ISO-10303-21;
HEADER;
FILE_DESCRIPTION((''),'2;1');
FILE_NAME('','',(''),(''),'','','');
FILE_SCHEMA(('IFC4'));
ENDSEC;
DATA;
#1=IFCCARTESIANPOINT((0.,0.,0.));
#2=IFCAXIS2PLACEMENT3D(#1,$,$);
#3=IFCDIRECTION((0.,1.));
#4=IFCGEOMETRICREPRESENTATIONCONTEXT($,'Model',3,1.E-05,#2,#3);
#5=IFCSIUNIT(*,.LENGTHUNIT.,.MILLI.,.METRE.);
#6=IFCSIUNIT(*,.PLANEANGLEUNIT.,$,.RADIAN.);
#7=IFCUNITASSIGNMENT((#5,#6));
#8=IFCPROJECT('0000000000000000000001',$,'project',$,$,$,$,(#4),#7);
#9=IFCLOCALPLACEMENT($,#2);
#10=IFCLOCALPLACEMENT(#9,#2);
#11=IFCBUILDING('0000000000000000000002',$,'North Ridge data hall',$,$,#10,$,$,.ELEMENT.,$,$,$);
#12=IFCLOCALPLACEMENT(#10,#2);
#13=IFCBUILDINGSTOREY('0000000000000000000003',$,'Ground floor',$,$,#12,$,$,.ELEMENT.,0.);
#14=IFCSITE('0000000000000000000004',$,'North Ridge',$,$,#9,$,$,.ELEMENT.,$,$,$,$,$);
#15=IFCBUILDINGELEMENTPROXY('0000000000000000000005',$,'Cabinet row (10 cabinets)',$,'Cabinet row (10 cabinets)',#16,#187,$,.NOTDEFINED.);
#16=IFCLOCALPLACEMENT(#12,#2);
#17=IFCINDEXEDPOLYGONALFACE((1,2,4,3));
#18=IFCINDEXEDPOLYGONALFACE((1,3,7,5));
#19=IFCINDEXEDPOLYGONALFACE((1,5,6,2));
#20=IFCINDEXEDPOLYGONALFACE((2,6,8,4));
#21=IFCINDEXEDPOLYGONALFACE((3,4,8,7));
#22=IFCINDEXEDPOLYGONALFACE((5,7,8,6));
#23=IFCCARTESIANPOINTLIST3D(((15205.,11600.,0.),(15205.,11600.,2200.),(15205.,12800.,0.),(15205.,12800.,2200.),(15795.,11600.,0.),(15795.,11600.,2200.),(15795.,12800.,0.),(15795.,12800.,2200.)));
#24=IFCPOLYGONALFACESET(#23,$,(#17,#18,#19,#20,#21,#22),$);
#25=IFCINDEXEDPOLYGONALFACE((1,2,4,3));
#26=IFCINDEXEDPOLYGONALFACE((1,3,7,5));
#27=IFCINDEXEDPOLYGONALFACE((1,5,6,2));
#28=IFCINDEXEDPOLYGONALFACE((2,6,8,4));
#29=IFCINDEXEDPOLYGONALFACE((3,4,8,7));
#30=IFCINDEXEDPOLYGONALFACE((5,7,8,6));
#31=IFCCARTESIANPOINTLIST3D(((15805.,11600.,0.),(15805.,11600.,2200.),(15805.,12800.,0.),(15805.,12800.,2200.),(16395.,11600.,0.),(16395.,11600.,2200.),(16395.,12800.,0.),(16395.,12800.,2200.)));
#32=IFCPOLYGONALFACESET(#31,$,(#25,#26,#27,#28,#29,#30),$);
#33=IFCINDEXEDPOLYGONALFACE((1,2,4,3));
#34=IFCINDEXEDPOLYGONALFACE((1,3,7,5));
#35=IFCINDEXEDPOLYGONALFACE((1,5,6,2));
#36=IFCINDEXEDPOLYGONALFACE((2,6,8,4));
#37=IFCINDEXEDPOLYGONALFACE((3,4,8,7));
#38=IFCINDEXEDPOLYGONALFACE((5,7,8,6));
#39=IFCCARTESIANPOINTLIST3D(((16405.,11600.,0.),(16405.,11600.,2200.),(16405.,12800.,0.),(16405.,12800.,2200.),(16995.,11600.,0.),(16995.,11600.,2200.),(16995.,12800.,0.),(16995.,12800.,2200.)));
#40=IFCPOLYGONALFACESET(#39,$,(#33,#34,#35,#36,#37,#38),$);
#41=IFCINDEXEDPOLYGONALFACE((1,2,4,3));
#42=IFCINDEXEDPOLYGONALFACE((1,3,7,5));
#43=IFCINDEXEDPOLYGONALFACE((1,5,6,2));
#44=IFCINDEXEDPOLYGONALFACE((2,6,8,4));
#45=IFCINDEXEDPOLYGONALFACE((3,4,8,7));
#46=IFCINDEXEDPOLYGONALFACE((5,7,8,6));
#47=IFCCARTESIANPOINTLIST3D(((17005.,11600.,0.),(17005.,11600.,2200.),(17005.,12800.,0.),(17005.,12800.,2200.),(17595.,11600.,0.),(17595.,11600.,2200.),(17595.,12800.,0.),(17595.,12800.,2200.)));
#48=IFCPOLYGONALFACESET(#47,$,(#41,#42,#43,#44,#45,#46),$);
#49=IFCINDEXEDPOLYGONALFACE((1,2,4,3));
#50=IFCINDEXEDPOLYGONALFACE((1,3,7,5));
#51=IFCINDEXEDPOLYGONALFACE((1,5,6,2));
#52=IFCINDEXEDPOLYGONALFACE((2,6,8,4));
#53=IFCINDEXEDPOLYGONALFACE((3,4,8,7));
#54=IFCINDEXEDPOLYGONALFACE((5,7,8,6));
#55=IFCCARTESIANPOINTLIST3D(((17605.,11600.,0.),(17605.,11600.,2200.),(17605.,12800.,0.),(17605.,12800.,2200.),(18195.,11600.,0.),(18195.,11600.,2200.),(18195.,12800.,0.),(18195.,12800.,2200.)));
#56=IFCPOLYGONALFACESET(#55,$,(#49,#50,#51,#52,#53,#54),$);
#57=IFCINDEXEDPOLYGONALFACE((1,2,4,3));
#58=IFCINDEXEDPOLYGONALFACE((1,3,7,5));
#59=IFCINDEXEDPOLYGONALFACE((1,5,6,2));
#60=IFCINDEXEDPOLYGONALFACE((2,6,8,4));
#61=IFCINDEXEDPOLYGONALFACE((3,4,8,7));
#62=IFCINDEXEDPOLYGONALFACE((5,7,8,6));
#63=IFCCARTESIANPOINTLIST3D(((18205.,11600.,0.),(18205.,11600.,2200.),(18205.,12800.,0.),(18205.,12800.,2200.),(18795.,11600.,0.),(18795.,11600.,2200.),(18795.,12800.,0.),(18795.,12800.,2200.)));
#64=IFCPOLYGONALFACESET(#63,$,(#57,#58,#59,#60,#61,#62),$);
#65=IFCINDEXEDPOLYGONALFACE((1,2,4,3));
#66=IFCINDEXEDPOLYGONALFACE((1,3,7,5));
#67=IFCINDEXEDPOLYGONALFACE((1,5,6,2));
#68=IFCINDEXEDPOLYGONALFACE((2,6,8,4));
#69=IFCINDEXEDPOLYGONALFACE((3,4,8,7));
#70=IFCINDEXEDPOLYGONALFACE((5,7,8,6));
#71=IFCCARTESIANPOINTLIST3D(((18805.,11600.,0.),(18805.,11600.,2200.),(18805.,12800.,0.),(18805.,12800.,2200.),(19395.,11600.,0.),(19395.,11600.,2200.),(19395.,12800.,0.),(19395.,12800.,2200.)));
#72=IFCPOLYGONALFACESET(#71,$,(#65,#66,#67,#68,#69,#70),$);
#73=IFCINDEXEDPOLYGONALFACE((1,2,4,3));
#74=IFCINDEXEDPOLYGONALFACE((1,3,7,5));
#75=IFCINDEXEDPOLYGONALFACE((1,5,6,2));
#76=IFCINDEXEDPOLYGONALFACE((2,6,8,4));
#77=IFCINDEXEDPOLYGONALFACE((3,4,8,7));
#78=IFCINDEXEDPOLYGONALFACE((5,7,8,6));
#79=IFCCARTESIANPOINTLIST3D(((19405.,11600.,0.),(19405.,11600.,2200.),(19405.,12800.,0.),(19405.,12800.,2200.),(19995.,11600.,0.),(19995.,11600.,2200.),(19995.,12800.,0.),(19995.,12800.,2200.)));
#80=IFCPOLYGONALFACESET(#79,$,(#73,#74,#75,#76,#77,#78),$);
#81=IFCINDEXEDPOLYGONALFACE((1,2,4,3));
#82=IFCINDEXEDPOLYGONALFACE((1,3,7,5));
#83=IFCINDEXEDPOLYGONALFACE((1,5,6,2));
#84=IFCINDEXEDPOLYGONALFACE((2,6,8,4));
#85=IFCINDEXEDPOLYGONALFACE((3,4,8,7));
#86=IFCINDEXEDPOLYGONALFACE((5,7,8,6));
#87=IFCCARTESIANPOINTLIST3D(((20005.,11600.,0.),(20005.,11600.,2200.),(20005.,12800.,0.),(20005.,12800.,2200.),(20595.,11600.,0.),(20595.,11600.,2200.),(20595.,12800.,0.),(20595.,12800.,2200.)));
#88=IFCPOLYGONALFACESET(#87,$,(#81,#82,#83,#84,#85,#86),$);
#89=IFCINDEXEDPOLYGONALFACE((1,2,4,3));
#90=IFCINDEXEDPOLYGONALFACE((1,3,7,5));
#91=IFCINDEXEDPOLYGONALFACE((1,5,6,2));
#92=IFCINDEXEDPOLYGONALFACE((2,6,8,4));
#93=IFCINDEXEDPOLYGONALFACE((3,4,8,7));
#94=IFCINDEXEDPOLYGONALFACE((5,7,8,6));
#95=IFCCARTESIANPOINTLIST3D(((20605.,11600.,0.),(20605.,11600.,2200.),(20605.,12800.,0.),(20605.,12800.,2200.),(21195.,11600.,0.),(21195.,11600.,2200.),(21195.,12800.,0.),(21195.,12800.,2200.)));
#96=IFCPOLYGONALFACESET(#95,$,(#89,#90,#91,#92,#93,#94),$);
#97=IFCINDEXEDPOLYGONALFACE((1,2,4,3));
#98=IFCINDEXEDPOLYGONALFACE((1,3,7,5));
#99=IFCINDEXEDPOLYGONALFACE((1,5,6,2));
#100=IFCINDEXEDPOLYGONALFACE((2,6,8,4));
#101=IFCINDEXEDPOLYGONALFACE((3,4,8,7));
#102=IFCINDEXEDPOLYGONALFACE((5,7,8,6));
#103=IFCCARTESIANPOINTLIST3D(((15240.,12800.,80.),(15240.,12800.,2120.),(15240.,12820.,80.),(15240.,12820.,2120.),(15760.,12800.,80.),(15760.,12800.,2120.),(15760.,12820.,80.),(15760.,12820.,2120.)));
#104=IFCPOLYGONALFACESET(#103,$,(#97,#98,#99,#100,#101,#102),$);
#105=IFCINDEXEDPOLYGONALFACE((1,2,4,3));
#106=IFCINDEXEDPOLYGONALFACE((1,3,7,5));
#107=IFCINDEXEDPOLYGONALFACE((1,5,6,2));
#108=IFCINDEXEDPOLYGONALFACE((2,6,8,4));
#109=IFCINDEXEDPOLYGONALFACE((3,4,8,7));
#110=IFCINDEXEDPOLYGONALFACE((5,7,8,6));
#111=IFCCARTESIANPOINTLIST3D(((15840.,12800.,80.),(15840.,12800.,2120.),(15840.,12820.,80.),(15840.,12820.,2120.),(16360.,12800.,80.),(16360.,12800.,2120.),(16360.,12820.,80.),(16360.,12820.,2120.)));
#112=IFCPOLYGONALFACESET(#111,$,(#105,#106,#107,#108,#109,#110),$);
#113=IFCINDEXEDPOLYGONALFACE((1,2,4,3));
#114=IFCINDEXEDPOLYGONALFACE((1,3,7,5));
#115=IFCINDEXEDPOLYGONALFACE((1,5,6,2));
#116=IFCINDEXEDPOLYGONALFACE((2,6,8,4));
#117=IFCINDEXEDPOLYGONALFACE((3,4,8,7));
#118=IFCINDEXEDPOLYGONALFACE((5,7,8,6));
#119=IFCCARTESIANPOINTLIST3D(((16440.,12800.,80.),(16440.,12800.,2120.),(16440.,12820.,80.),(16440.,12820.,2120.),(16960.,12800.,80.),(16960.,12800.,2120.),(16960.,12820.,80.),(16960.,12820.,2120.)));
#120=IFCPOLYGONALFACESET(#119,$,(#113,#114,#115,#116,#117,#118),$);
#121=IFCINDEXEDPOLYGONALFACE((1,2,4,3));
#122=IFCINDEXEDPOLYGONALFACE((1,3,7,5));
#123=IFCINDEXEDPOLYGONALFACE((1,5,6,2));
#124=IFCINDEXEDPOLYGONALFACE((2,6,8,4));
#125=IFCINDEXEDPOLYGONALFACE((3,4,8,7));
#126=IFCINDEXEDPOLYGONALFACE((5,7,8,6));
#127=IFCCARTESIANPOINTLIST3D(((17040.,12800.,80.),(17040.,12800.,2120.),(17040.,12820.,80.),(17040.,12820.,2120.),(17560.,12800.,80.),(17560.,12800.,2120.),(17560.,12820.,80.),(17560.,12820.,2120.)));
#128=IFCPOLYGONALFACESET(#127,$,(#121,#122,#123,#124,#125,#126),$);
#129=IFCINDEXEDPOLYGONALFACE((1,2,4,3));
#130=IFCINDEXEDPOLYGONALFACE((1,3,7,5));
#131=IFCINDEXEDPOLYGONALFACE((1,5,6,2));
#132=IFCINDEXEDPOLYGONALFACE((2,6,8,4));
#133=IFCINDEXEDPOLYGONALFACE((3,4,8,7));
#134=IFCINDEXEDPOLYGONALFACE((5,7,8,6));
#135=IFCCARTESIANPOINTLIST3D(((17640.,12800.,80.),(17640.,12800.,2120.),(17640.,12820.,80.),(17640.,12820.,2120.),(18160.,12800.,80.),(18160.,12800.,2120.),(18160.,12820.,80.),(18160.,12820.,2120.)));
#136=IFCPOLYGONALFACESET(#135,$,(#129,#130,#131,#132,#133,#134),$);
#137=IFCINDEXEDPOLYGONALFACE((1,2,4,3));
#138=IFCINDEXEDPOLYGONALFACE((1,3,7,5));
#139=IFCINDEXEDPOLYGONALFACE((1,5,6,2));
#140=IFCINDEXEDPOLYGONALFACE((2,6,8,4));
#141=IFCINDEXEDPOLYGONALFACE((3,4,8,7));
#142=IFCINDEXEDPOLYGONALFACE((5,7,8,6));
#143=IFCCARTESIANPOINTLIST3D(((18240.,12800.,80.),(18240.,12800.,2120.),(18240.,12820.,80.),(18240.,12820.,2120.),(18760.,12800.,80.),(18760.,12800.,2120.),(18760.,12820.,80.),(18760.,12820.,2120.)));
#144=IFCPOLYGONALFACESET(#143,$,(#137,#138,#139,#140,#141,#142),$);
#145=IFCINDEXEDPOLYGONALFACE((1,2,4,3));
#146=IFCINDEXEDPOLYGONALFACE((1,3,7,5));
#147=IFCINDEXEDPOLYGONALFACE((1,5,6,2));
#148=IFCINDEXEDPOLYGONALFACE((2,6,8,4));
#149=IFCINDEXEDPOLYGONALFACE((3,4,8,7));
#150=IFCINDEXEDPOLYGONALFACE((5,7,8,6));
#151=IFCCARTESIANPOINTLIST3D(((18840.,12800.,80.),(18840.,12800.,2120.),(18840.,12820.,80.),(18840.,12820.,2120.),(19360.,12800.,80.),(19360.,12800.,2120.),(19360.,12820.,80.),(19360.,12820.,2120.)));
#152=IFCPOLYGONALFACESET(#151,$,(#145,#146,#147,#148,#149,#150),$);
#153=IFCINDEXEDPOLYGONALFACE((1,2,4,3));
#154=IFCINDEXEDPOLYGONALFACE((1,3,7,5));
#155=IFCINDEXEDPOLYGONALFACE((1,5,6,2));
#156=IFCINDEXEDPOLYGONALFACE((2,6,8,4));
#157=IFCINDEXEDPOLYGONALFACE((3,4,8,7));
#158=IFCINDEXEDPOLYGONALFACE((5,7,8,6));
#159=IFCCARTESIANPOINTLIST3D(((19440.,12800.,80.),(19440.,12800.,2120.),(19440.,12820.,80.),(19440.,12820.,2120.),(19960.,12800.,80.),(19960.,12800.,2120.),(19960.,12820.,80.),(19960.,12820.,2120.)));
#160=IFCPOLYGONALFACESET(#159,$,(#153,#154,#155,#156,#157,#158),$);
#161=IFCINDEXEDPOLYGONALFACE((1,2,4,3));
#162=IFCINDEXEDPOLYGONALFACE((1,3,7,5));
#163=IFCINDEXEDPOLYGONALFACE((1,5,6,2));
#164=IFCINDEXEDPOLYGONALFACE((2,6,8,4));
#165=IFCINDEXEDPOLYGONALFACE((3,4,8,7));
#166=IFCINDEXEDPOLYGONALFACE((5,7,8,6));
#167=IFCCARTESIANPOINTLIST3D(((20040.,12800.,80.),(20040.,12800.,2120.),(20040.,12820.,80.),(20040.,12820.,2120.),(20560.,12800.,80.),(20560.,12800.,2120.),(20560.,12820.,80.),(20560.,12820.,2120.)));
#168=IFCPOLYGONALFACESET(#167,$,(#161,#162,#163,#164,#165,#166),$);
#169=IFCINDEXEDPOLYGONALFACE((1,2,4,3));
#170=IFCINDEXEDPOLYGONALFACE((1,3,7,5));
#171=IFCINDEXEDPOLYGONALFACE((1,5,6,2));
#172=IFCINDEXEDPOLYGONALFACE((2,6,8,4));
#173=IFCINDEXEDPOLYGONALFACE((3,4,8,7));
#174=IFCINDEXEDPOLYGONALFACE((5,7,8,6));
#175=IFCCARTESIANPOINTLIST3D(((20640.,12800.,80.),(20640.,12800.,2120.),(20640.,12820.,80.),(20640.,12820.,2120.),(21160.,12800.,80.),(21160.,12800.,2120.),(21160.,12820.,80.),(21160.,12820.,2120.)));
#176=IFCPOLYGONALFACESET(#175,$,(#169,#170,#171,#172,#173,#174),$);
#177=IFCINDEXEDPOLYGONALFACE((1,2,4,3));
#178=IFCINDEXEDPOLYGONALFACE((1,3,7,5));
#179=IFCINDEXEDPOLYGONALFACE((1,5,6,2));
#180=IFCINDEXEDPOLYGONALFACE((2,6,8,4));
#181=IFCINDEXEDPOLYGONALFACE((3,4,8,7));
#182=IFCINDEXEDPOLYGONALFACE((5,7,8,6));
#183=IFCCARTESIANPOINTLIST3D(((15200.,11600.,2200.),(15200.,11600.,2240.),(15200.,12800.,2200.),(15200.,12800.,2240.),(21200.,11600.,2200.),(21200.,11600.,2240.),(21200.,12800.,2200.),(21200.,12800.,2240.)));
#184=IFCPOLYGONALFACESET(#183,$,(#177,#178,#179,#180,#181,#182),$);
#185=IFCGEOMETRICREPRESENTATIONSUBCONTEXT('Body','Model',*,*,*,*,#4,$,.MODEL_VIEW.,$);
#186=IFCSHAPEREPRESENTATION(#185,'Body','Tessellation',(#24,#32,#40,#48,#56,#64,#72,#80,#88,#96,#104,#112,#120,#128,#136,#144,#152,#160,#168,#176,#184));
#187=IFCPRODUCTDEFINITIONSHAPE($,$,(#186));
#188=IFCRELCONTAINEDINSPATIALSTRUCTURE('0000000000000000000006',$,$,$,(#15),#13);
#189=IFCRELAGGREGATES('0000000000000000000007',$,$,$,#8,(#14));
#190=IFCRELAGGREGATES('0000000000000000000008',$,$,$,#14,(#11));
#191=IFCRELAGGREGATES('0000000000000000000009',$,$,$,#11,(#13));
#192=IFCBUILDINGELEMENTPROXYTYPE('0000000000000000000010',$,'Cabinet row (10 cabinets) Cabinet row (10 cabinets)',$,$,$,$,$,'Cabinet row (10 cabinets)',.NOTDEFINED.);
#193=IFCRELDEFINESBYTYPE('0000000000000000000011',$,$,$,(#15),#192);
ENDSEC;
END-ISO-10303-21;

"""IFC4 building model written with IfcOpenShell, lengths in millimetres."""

from ifc_helpers import new_model, si_unit, direction, frame, origin, place, context, subcontext, project, spatial, polyline, outline, extrude, source, transform, mapped, type_object, type_shapes, element, save


model = new_model("IFC4")

# Units and contexts
model_context = context("Model", 3, precision=1e-05, world=origin(), true_north=direction((0.0, 1.0)))
body_context = subcontext(model_context, "Body", "Model", "MODEL_VIEW")
ifc_project = project(units=[si_unit("LENGTHUNIT", "METRE", prefix="MILLI"), si_unit("PLANEANGLEUNIT", "RADIAN")], contexts=[model_context])

# Site, building, storey
site_placement = place(None, origin())
site = spatial("IfcSite", under=ifc_project, at=site_placement, Name="North Ridge", CompositionType="ELEMENT")
building_placement = place(site_placement, origin())
building = spatial("IfcBuilding", under=site, at=building_placement, Name="North Ridge data hall", CompositionType="ELEMENT")
storey_placement = place(building_placement, origin())
storey = spatial("IfcBuildingStorey", under=building, at=storey_placement, Name="Ground floor", CompositionType="ELEMENT", Elevation=0.0)

# Building element proxy
building_element_proxy_type_1 = type_object("IfcBuildingElementProxyType", Name="Cabinet row (10 cabinets) Cabinet row (10 cabinets)", ElementType="Cabinet row (10 cabinets)", PredefinedType="NOTDEFINED")
shared_shape_1 = source(origin(), body_context, "Body", "SweptSolid", [
    extrude(outline(polyline([(5.0, 0.0), (595.0, 0.0), (595.0, 1200.0), (5.0, 1200.0), (5.0, 0.0)])), origin(), (0.0, 0.0, 1.0), 2200.0),
    extrude(outline(polyline([(605.0, 0.0), (1195.0, 0.0), (1195.0, 1200.0), (605.0, 1200.0), (605.0, 0.0)])), origin(), (0.0, 0.0, 1.0), 2200.0),
    extrude(outline(polyline([(1205.0, 0.0), (1795.0, 0.0), (1795.0, 1200.0), (1205.0, 1200.0), (1205.0, 0.0)])), origin(), (0.0, 0.0, 1.0), 2200.0),
    extrude(outline(polyline([(1805.0, 0.0), (2395.0, 0.0), (2395.0, 1200.0), (1805.0, 1200.0), (1805.0, 0.0)])), origin(), (0.0, 0.0, 1.0), 2200.0),
    extrude(outline(polyline([(2405.0, 0.0), (2995.0, 0.0), (2995.0, 1200.0), (2405.0, 1200.0), (2405.0, 0.0)])), origin(), (0.0, 0.0, 1.0), 2200.0),
    extrude(outline(polyline([(3005.0, 0.0), (3595.0, 0.0), (3595.0, 1200.0), (3005.0, 1200.0), (3005.0, 0.0)])), origin(), (0.0, 0.0, 1.0), 2200.0),
    extrude(outline(polyline([(3605.0, 0.0), (4195.0, 0.0), (4195.0, 1200.0), (3605.0, 1200.0), (3605.0, 0.0)])), origin(), (0.0, 0.0, 1.0), 2200.0),
    extrude(outline(polyline([(4205.0, 0.0), (4795.0, 0.0), (4795.0, 1200.0), (4205.0, 1200.0), (4205.0, 0.0)])), origin(), (0.0, 0.0, 1.0), 2200.0),
    extrude(outline(polyline([(4805.0, 0.0), (5395.0, 0.0), (5395.0, 1200.0), (4805.0, 1200.0), (4805.0, 0.0)])), origin(), (0.0, 0.0, 1.0), 2200.0),
    extrude(outline(polyline([(5405.0, 0.0), (5995.0, 0.0), (5995.0, 1200.0), (5405.0, 1200.0), (5405.0, 0.0)])), origin(), (0.0, 0.0, 1.0), 2200.0),
    extrude(outline(polyline([(40.0, 1200.0), (560.0, 1200.0), (560.0, 1220.0), (40.0, 1220.0), (40.0, 1200.0)])), frame((0.0, 0.0, 80.0)), (0.0, 0.0, 1.0), 2040.0),
    extrude(outline(polyline([(640.0, 1200.0), (1160.0, 1200.0), (1160.0, 1220.0), (640.0, 1220.0), (640.0, 1200.0)])), frame((0.0, 0.0, 80.0)), (0.0, 0.0, 1.0), 2040.0),
    extrude(outline(polyline([(1240.0, 1200.0), (1760.0, 1200.0), (1760.0, 1220.0), (1240.0, 1220.0), (1240.0, 1200.0)])), frame((0.0, 0.0, 80.0)), (0.0, 0.0, 1.0), 2040.0),
    extrude(outline(polyline([(1840.0, 1200.0), (2360.0, 1200.0), (2360.0, 1220.0), (1840.0, 1220.0), (1840.0, 1200.0)])), frame((0.0, 0.0, 80.0)), (0.0, 0.0, 1.0), 2040.0),
    extrude(outline(polyline([(2440.0, 1200.0), (2960.0, 1200.0), (2960.0, 1220.0), (2440.0, 1220.0), (2440.0, 1200.0)])), frame((0.0, 0.0, 80.0)), (0.0, 0.0, 1.0), 2040.0),
    extrude(outline(polyline([(3040.0, 1200.0), (3560.0, 1200.0), (3560.0, 1220.0), (3040.0, 1220.0), (3040.0, 1200.0)])), frame((0.0, 0.0, 80.0)), (0.0, 0.0, 1.0), 2040.0),
    extrude(outline(polyline([(3640.0, 1200.0), (4160.0, 1200.0), (4160.0, 1220.0), (3640.0, 1220.0), (3640.0, 1200.0)])), frame((0.0, 0.0, 80.0)), (0.0, 0.0, 1.0), 2040.0),
    extrude(outline(polyline([(4240.0, 1200.0), (4760.0, 1200.0), (4760.0, 1220.0), (4240.0, 1220.0), (4240.0, 1200.0)])), frame((0.0, 0.0, 80.0)), (0.0, 0.0, 1.0), 2040.0),
    extrude(outline(polyline([(4840.0, 1200.0), (5360.0, 1200.0), (5360.0, 1220.0), (4840.0, 1220.0), (4840.0, 1200.0)])), frame((0.0, 0.0, 80.0)), (0.0, 0.0, 1.0), 2040.0),
    extrude(outline(polyline([(5440.0, 1200.0), (5960.0, 1200.0), (5960.0, 1220.0), (5440.0, 1220.0), (5440.0, 1200.0)])), frame((0.0, 0.0, 80.0)), (0.0, 0.0, 1.0), 2040.0),
    extrude(outline(polyline([(0.0, 0.0), (6000.0, 0.0), (6000.0, 1200.0), (0.0, 1200.0), (0.0, 0.0)])), frame((0.0, 0.0, 2200.0)), (0.0, 0.0, 1.0), 40.0),
])
type_shapes(building_element_proxy_type_1, [shared_shape_1])
for number, where, z_axis, x_axis, name in (
    (1, (15200.0, 11600.0, 0.0), (0.0, 0.0, 1.0), (1.0, 0.0, 0.0), "Cabinet row (10 cabinets)"),
):
    element("IfcBuildingElementProxy", number, at=place(storey_placement, frame(where, z_axis=z_axis, x_axis=x_axis)), inside=storey, type_object=building_element_proxy_type_1, Name=name, ObjectType="Cabinet row (10 cabinets)", PredefinedType="NOTDEFINED", context=body_context, shape_type="MappedRepresentation", body=[
        mapped(shared_shape_1, transform((0.0, 0.0, 0.0))),
    ])

save(model, "model.ifc")
